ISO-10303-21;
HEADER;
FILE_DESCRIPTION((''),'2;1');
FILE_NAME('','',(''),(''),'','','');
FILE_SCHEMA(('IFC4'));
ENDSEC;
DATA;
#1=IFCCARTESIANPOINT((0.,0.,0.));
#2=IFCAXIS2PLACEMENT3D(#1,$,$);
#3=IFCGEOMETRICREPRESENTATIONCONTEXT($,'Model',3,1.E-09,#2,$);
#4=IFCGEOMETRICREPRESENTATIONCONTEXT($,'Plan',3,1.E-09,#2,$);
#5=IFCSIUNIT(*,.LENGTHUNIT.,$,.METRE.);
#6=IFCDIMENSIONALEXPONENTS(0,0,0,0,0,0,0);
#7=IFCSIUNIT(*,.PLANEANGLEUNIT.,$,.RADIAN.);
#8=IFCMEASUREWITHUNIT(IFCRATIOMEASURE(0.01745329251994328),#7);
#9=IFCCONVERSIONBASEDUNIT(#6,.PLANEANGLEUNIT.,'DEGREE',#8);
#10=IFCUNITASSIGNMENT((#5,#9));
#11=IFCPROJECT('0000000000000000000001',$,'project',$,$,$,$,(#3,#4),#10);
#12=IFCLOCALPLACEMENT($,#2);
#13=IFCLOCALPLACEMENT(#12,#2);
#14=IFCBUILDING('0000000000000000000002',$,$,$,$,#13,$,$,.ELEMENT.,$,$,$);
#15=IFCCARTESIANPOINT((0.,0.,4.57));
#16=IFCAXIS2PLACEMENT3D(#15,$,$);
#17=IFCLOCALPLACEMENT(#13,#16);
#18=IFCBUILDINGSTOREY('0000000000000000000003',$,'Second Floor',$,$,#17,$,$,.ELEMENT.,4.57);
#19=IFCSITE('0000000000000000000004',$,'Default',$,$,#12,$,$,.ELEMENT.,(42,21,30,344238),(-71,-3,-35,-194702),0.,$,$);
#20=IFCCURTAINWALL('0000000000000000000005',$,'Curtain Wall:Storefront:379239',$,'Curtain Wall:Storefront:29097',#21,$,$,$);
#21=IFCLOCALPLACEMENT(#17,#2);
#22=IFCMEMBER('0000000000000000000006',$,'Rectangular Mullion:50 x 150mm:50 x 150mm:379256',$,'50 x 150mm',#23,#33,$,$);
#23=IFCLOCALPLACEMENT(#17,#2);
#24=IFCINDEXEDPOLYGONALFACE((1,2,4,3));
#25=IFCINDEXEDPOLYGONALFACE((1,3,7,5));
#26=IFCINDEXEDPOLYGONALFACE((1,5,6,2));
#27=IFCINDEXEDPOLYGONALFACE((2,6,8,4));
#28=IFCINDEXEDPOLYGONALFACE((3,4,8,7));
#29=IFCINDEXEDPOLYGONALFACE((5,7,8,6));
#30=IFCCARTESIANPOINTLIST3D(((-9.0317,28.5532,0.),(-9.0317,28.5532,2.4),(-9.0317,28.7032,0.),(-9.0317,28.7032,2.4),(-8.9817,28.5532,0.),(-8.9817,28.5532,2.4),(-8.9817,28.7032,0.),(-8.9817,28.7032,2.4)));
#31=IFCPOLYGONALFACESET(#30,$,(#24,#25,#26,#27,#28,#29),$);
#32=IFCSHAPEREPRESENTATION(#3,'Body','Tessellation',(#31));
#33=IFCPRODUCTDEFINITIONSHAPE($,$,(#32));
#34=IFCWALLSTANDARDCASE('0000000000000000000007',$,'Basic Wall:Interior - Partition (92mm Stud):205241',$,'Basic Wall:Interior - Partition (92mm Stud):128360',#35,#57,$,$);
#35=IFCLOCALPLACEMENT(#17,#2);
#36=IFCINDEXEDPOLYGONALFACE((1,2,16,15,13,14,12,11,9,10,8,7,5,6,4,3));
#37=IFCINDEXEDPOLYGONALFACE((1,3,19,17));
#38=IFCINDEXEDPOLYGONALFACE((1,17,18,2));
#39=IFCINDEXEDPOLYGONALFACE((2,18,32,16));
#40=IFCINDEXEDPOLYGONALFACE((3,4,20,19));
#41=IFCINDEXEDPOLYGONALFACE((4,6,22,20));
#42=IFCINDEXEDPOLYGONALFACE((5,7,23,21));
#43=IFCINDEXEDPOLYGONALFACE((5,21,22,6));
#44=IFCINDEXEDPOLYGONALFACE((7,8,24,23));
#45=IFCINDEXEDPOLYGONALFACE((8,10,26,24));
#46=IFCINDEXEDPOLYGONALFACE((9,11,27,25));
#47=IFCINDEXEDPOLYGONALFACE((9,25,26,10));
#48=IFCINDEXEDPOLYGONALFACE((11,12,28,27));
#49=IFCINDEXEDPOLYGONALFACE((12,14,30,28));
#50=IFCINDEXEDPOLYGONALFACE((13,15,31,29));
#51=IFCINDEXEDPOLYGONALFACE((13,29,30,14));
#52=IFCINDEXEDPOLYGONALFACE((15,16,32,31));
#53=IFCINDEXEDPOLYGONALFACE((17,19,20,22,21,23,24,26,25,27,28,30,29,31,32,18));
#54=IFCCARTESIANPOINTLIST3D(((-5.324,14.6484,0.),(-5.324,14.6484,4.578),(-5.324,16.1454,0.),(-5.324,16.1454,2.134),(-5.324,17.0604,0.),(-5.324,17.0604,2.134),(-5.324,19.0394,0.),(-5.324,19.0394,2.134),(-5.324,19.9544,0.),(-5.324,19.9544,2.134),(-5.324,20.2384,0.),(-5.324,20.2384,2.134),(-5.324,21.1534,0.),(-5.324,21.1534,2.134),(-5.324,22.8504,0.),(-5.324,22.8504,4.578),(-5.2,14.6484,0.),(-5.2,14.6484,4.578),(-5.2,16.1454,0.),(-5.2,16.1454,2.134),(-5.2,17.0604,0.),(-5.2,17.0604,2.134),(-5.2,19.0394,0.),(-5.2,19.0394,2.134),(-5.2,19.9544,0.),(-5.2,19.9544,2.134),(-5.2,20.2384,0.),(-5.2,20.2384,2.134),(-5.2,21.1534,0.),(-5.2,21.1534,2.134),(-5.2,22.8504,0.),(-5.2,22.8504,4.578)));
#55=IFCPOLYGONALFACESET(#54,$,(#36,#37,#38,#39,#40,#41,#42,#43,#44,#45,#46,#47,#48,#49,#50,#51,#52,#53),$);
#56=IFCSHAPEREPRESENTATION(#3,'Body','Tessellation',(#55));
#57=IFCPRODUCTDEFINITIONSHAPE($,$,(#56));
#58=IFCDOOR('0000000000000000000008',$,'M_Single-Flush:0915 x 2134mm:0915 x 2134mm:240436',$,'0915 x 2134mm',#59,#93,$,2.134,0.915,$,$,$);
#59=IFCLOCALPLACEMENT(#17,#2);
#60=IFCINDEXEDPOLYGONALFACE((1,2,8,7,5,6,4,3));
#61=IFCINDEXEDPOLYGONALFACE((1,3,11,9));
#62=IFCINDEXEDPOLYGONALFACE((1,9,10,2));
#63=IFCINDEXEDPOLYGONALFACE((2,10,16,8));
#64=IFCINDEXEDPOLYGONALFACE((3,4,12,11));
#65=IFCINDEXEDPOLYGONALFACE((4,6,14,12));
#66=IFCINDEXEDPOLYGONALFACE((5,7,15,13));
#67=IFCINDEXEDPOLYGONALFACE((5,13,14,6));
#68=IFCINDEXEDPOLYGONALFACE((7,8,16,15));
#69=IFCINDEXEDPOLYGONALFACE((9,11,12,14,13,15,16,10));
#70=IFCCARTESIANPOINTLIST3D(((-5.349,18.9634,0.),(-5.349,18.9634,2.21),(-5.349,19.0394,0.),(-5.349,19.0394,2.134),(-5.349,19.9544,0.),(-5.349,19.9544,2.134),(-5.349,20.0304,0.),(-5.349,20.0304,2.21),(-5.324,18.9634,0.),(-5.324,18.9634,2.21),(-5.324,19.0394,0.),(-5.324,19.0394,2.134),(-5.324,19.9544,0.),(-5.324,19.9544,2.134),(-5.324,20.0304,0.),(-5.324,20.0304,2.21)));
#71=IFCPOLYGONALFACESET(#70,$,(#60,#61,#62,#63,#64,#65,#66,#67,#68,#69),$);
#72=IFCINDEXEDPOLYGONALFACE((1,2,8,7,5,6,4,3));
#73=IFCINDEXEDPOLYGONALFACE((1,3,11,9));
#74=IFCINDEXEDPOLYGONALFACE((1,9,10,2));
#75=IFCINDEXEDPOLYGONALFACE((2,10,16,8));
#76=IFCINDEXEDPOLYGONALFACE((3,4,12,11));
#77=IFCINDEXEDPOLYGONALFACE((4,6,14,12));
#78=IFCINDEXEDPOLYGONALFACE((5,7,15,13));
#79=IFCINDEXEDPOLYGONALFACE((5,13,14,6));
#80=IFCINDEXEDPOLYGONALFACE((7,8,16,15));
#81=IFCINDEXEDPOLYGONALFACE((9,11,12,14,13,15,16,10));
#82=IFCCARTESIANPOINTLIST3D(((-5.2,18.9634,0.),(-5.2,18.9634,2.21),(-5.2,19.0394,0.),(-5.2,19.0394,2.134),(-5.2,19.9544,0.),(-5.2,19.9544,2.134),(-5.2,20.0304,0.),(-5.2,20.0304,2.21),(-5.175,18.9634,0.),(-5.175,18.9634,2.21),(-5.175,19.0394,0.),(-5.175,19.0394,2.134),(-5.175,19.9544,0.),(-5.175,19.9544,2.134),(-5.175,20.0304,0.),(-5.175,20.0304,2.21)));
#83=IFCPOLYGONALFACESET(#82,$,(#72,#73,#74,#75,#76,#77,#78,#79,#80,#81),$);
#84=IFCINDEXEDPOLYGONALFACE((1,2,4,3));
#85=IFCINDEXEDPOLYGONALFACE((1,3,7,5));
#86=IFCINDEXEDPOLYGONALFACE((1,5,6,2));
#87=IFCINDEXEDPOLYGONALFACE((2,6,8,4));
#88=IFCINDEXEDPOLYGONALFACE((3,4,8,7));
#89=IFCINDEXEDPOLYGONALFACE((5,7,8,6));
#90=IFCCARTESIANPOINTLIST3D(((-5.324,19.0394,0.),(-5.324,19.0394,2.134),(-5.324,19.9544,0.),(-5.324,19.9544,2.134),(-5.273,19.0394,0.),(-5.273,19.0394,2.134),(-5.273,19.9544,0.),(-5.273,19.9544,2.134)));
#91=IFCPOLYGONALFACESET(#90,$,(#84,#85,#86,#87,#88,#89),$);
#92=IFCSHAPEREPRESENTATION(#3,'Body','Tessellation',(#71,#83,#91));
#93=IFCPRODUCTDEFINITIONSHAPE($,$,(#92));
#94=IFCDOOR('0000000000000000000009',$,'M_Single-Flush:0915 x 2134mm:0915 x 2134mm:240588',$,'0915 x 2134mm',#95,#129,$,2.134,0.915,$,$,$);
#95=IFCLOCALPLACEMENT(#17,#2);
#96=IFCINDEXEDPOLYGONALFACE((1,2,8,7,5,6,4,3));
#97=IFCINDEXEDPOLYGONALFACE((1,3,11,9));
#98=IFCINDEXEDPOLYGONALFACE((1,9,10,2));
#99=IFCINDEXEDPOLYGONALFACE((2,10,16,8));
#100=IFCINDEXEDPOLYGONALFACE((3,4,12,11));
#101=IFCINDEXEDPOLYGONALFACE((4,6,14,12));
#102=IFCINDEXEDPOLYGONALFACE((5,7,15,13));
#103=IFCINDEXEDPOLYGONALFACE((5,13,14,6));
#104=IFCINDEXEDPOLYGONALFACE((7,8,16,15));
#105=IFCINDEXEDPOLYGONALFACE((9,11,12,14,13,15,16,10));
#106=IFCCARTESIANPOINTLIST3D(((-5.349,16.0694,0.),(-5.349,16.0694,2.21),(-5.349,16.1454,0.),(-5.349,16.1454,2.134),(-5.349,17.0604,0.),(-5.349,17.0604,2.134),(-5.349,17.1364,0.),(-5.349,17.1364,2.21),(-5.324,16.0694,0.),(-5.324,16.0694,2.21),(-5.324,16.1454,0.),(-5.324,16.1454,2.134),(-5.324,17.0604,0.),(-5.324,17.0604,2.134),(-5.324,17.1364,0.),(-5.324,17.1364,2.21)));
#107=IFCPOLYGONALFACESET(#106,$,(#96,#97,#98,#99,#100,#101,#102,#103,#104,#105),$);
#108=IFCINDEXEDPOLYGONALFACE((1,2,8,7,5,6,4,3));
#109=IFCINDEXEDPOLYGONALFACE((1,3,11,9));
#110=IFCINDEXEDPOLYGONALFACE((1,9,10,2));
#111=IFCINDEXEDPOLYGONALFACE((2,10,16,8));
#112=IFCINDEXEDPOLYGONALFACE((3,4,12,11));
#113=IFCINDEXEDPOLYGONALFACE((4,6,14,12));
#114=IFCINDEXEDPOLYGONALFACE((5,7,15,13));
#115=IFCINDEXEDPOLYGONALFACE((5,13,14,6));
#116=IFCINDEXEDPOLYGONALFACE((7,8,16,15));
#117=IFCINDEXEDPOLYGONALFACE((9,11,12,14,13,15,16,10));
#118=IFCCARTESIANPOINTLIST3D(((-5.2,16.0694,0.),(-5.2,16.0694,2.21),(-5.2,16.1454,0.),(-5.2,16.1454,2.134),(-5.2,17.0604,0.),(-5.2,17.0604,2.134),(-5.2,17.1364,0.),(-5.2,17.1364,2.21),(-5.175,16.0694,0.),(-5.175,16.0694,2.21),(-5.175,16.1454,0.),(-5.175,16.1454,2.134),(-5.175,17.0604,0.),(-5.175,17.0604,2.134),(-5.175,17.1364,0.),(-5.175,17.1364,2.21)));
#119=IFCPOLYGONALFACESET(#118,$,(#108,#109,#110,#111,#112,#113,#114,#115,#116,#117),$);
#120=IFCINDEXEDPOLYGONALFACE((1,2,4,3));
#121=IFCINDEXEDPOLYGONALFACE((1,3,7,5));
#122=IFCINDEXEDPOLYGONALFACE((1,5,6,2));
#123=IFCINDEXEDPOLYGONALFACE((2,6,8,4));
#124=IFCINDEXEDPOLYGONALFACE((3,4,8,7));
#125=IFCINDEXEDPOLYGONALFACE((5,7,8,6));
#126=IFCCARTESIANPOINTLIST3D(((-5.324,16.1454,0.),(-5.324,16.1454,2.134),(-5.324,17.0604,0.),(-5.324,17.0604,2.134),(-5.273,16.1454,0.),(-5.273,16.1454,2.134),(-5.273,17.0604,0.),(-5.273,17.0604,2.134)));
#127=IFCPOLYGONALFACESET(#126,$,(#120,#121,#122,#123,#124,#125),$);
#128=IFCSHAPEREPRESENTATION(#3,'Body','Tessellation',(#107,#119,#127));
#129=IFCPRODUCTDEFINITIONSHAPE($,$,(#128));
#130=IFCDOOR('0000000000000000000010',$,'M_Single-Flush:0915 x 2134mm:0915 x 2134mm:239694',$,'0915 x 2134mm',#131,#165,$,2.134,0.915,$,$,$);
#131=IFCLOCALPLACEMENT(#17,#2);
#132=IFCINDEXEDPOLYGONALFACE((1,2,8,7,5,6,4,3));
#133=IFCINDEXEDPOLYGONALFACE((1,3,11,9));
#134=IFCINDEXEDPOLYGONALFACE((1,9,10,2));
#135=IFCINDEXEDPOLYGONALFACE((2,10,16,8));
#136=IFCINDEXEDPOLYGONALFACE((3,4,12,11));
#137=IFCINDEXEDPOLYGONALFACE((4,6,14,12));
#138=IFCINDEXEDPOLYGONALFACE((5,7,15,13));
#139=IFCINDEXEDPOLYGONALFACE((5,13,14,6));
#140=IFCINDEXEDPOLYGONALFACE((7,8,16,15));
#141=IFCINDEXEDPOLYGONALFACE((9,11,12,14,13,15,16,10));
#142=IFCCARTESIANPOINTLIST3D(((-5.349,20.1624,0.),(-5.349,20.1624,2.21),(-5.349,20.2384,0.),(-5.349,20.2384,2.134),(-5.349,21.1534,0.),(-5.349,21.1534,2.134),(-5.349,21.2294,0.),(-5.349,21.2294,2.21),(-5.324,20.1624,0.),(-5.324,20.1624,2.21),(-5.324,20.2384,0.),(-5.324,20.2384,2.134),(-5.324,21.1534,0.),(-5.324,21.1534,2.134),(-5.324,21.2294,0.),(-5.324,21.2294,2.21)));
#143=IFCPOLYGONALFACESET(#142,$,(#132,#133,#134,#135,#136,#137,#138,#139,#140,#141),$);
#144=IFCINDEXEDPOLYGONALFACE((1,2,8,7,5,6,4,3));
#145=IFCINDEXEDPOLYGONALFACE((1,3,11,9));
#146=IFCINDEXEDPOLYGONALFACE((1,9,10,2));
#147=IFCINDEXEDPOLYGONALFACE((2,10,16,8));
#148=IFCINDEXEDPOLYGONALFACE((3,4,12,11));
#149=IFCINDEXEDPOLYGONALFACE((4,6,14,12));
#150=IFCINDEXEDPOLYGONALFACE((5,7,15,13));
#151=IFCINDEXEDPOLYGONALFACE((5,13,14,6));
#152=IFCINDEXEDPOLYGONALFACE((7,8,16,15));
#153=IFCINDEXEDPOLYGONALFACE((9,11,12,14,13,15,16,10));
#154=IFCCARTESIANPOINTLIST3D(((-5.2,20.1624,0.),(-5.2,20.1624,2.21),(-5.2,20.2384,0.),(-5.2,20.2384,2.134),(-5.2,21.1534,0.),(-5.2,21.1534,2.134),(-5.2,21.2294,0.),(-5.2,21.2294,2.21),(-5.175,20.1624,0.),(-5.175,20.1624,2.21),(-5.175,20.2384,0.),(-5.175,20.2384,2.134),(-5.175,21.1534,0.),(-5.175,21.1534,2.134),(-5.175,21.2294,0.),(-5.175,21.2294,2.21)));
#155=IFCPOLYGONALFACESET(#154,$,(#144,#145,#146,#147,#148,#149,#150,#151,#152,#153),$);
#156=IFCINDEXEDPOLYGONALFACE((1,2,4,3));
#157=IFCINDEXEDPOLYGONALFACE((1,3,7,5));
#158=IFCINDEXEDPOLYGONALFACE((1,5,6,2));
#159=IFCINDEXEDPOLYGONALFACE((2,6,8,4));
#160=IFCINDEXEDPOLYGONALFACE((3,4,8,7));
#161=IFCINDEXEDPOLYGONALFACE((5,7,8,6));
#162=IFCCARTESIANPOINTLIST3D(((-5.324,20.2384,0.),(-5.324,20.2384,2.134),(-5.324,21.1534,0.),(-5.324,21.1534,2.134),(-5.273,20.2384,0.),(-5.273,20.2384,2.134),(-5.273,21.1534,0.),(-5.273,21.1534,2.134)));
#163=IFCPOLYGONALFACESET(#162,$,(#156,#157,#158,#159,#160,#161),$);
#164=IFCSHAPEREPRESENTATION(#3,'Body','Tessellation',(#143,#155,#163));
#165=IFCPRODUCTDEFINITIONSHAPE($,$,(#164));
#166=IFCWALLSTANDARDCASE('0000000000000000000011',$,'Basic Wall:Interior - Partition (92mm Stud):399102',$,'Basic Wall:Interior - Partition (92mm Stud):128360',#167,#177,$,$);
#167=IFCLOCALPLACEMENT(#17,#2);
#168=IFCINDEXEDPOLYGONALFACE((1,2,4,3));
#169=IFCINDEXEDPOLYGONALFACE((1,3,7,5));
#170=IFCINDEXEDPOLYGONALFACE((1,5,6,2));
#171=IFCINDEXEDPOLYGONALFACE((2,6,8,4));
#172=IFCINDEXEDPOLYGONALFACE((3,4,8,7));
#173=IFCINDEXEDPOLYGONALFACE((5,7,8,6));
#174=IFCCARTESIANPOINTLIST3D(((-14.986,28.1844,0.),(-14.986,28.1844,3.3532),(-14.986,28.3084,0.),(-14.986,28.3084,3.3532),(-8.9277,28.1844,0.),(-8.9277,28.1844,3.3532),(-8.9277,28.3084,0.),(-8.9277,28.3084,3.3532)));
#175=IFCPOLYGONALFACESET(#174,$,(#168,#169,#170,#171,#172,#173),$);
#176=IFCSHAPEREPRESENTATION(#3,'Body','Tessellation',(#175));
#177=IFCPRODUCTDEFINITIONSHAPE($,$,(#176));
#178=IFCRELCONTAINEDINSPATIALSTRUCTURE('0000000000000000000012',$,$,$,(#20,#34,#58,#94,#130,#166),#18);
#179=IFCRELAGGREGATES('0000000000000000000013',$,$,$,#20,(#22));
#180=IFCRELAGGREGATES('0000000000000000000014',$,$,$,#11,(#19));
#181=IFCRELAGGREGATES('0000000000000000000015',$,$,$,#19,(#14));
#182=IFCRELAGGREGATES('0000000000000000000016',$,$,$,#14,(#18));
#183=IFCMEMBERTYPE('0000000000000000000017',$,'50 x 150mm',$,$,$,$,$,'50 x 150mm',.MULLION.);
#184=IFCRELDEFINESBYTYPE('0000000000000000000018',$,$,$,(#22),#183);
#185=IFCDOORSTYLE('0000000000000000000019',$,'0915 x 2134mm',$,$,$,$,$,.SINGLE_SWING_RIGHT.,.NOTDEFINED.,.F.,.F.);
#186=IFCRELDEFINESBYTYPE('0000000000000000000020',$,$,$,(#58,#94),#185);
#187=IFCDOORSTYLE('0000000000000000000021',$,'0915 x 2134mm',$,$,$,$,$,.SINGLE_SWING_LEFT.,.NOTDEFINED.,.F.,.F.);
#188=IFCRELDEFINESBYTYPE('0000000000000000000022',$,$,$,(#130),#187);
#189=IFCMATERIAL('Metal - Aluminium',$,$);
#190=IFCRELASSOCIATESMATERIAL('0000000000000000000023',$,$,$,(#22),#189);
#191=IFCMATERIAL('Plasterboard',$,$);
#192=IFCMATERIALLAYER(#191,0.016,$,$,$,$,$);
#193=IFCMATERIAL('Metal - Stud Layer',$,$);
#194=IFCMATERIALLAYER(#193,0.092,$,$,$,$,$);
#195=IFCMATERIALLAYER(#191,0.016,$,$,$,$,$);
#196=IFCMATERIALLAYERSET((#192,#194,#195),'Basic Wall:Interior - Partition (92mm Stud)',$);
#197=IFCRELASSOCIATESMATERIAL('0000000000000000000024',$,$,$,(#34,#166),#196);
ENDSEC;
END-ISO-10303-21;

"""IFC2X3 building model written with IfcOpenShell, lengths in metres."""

from ifc_helpers import new_model, entity, si_unit, converted_unit, frame, frame_2d, origin, origin_2d_with_axis, place, context, project, spatial, polyline, rectangle, outline, extrude, source, transform, mapped, material, layer, layer_set, layer_usage, type_object, type_shapes, element, fill, aggregate, save


model = new_model("IFC2X3")

# Units and contexts
model_context = context("Model", 3, precision=1e-09, world=origin())
plan_context = context("Plan", 3, precision=1e-09, world=origin())
ifc_project = project(units=[si_unit("LENGTHUNIT", "METRE"), converted_unit("PLANEANGLEUNIT", "DEGREE", entity("IfcRatioMeasure", 0.01745329251994328), si_unit("PLANEANGLEUNIT", "RADIAN"), dimensions=[0, 0, 0, 0, 0, 0, 0])], contexts=[model_context, plan_context])

# Site, building, storey
site_placement = place(None, origin())
site = spatial("IfcSite", under=ifc_project, at=site_placement, Name="Default", CompositionType="ELEMENT", RefLatitude=(42, 21, 30, 344238), RefLongitude=(-71, -3, -35, -194702), RefElevation=0.0)
building_placement = place(site_placement, origin())
building = spatial("IfcBuilding", under=site, at=building_placement, CompositionType="ELEMENT")
storey_placement = place(building_placement, frame((0.0, 0.0, 4.57)))
storey = spatial("IfcBuildingStorey", under=building, at=storey_placement, Name="Second Floor", CompositionType="ELEMENT", Elevation=4.57)

# Curtain wall, member
curtain_wall_1_placement = place(storey_placement, origin())
curtain_wall_1 = element("IfcCurtainWall", 1, at=curtain_wall_1_placement, inside=storey, Name="Curtain Wall:Storefront:379239", ObjectType="Curtain Wall:Storefront:29097")
ifc_material_1 = material(Name="Metal - Aluminium")
member_type_1 = type_object("IfcMemberType", Name="50 x 150mm", ElementType="50 x 150mm", PredefinedType="MULLION")
shared_shape_1 = source(origin(), model_context, "Body", "SweptSolid", [
    extrude(rectangle(XDim=0.05, YDim=0.15, at=origin_2d_with_axis()), frame((-0.025, 0.0, -2.4), z_axis=(0.0, 0.0, 1.0), x_axis=(-1.0, 0.0, 0.0)), (0.0, 0.0, 1.0), 2.4),
])
type_shapes(member_type_1, [shared_shape_1])
member_1_placement = place(storey_placement, frame((-8.9817, 28.6282, 2.4)))
member_1 = element("IfcMember", 2, at=member_1_placement, type_object=member_type_1, material=ifc_material_1, Name="Rectangular Mullion:50 x 150mm:50 x 150mm:379256", ObjectType="50 x 150mm", context=model_context, shape_type="MappedRepresentation", body=[
    mapped(shared_shape_1, transform((0.0, 0.0, 0.0), scale=1.0)),
])
aggregate(curtain_wall_1, [member_1])

# Wall, openings, doors
ifc_material_2 = material(Name="Plasterboard")
ifc_layer_1 = layer(ifc_material_2, 0.016)
ifc_material_3 = material(Name="Metal - Stud Layer")
ifc_layer_2 = layer(ifc_material_3, 0.092)
ifc_layer_3 = layer(ifc_material_2, 0.016)
ifc_layer_set_1 = layer_set([ifc_layer_1, ifc_layer_2, ifc_layer_3], Name="Basic Wall:Interior - Partition (92mm Stud)")
ifc_layer_usage_1 = layer_usage(ifc_layer_set_1, "AXIS2", "NEGATIVE", 0.062)
wall_1_placement = place(storey_placement, frame((-5.262, 22.8504, 0.0), z_axis=(0.0, 0.0, 1.0), x_axis=(0.0, -1.0, 0.0)))
wall_1 = element("IfcWallStandardCase", 3, at=wall_1_placement, inside=storey, material=ifc_layer_usage_1, Name="Basic Wall:Interior - Partition (92mm Stud):205241", ObjectType="Basic Wall:Interior - Partition (92mm Stud):128360", context=model_context, shape_type="SweptSolid", body=[
    extrude(rectangle(XDim=8.202, YDim=0.124, at=frame_2d((4.101, 0.0), x_axis=(-1.0, 0.0))), origin(), (0.0, 0.0, 1.0), 4.578),
])
opening_1_placement = place(wall_1_placement, frame((3.811, 0.062, 0.0)))
opening_1 = element("IfcOpeningElement", 4, at=opening_1_placement, cuts=wall_1, ObjectType="Opening", context=model_context, shape_type="SweptSolid", body=[
    extrude(rectangle(XDim=0.915, YDim=2.134, at=frame_2d((1.067, 0.4575), x_axis=(0.0, 1.0))), frame((0.0, 0.0, 0.0), z_axis=(0.0, -1.0, 0.0), x_axis=(0.0, 0.0, 1.0)), (0.0, 0.0, 1.0), 0.124),
])
opening_2_placement = place(wall_1_placement, frame((6.705, 0.062, 0.0)))
opening_2 = element("IfcOpeningElement", 5, at=opening_2_placement, cuts=wall_1, ObjectType="Opening", context=model_context, shape_type="SweptSolid", body=[
    extrude(rectangle(XDim=0.915, YDim=2.134, at=frame_2d((1.067, 0.4575), x_axis=(0.0, 1.0))), frame((0.0, 0.0, 0.0), z_axis=(0.0, -1.0, 0.0), x_axis=(0.0, 0.0, 1.0)), (0.0, 0.0, 1.0), 0.124),
])
opening_3_placement = place(wall_1_placement, frame((2.612, 0.062, 0.0)))
opening_3 = element("IfcOpeningElement", 6, at=opening_3_placement, cuts=wall_1, ObjectType="Opening", context=model_context, shape_type="SweptSolid", body=[
    extrude(rectangle(XDim=0.915, YDim=2.134, at=frame_2d((1.067, 0.4575), x_axis=(0.0, -1.0))), frame((0.0, 0.0, 0.0), z_axis=(0.0, -1.0, 0.0), x_axis=(0.0, 0.0, 1.0)), (0.0, 0.0, 1.0), 0.124),
])
door_style_1 = type_object("IfcDoorStyle", Name="0915 x 2134mm", ConstructionType="NOTDEFINED", OperationType="SINGLE_SWING_RIGHT", ParameterTakesPrecedence=False, Sizeable=False)
shared_shape_2 = source(origin(), model_context, "Body", "SweptSolid", [
    extrude(outline(polyline([(-0.5335, -1.124), (0.5335, -1.124), (0.5335, 1.086), (0.4575, 1.086), (0.4575, -1.048), (-0.4575, -1.048), (-0.4575, 1.086), (-0.5335, 1.086), (-0.5335, -1.124)])), frame((0.4575, 0.124, 1.086), z_axis=(0.0, 1.0, 0.0), x_axis=(1.0, 0.0, 0.0)), (0.0, 0.0, 1.0), 0.025),
    extrude(outline(polyline([(-1.124, -0.5335), (1.086, -0.5335), (1.086, -0.4575), (-1.048, -0.4575), (-1.048, 0.4575), (1.086, 0.4575), (1.086, 0.5335), (-1.124, 0.5335), (-1.124, -0.5335)])), frame((0.4575, -0.025, 1.086), z_axis=(0.0, 1.0, 0.0), x_axis=(0.0, 0.0, -1.0)), (0.0, 0.0, 1.0), 0.025),
    extrude(rectangle(XDim=0.051, YDim=0.915, at=origin_2d_with_axis()), frame((0.4575, 0.0985, 0.0), z_axis=(0.0, 0.0, 1.0), x_axis=(0.0, 1.0, 0.0)), (0.0, 0.0, 1.0), 2.134),
])
type_shapes(door_style_1, [shared_shape_2])
door_1_placement = place(opening_1_placement, frame((0.0, 0.0, 0.0), z_axis=(0.0, 0.0, 1.0), x_axis=(-1.0, 0.0, 0.0)))
door_1 = element("IfcDoor", 7, at=door_1_placement, inside=storey, type_object=door_style_1, Name="M_Single-Flush:0915 x 2134mm:0915 x 2134mm:240436", ObjectType="0915 x 2134mm", OverallHeight=2.134, OverallWidth=0.915, context=model_context, shape_type="MappedRepresentation", body=[
    mapped(shared_shape_2, transform((0.0, 0.0, 0.0), scale=1.0)),
])
fill(opening_1, door_1)
door_2_placement = place(opening_2_placement, frame((0.0, 0.0, 0.0), z_axis=(0.0, 0.0, 1.0), x_axis=(-1.0, 0.0, 0.0)))
door_2 = element("IfcDoor", 8, at=door_2_placement, inside=storey, type_object=door_style_1, Name="M_Single-Flush:0915 x 2134mm:0915 x 2134mm:240588", ObjectType="0915 x 2134mm", OverallHeight=2.134, OverallWidth=0.915, context=model_context, shape_type="MappedRepresentation", body=[
    mapped(shared_shape_2, transform((0.0, 0.0, 0.0), scale=1.0)),
])
fill(opening_2, door_2)
door_style_2 = type_object("IfcDoorStyle", Name="0915 x 2134mm", ConstructionType="NOTDEFINED", OperationType="SINGLE_SWING_LEFT", ParameterTakesPrecedence=False, Sizeable=False)
shared_shape_3 = source(origin(), model_context, "Body", "SweptSolid", [
    extrude(outline(polyline([(-0.5335, -1.124), (0.5335, -1.124), (0.5335, 1.086), (0.4575, 1.086), (0.4575, -1.048), (-0.4575, -1.048), (-0.4575, 1.086), (-0.5335, 1.086), (-0.5335, -1.124)])), frame((0.4575, 0.149, 1.086), z_axis=(0.0, -1.0, 0.0), x_axis=(-1.0, 0.0, 0.0)), (0.0, 0.0, 1.0), 0.025),
    extrude(outline(polyline([(-1.124, -0.5335), (1.086, -0.5335), (1.086, -0.4575), (-1.048, -0.4575), (-1.048, 0.4575), (1.086, 0.4575), (1.086, 0.5335), (-1.124, 0.5335), (-1.124, -0.5335)])), frame((0.4575, 0.0, 1.086), z_axis=(0.0, -1.0, 0.0), x_axis=(0.0, 0.0, -1.0)), (0.0, 0.0, 1.0), 0.025),
    extrude(rectangle(XDim=0.915, YDim=0.051, at=origin_2d_with_axis()), frame((0.4575, 0.0985, 0.0)), (0.0, 0.0, 1.0), 2.134),
])
type_shapes(door_style_2, [shared_shape_3])
door_3_placement = place(opening_3_placement, frame((0.0, 0.0, 0.0), z_axis=(0.0, 0.0, 1.0), x_axis=(-1.0, 0.0, 0.0)))
door_3 = element("IfcDoor", 9, at=door_3_placement, inside=storey, type_object=door_style_2, Name="M_Single-Flush:0915 x 2134mm:0915 x 2134mm:239694", ObjectType="0915 x 2134mm", OverallHeight=2.134, OverallWidth=0.915, context=model_context, shape_type="MappedRepresentation", body=[
    mapped(shared_shape_3, transform((0.0, 0.0, 0.0), scale=1.0)),
])
fill(opening_3, door_3)

# Wall
wall_2_placement = place(storey_placement, frame((-8.9277, 28.2464, 0.0), z_axis=(0.0, 0.0, 1.0), x_axis=(-1.0, 0.0, 0.0)))
element("IfcWallStandardCase", 10, at=wall_2_placement, inside=storey, material=ifc_layer_usage_1, Name="Basic Wall:Interior - Partition (92mm Stud):399102", ObjectType="Basic Wall:Interior - Partition (92mm Stud):128360", context=model_context, shape_type="SweptSolid", body=[
    extrude(rectangle(XDim=6.0582, YDim=0.124, at=frame_2d((3.0291, 0.0), x_axis=(-1.0, 0.0))), origin(), (0.0, 0.0, 1.0), 3.3532),
])

save(model, "model.ifc")
